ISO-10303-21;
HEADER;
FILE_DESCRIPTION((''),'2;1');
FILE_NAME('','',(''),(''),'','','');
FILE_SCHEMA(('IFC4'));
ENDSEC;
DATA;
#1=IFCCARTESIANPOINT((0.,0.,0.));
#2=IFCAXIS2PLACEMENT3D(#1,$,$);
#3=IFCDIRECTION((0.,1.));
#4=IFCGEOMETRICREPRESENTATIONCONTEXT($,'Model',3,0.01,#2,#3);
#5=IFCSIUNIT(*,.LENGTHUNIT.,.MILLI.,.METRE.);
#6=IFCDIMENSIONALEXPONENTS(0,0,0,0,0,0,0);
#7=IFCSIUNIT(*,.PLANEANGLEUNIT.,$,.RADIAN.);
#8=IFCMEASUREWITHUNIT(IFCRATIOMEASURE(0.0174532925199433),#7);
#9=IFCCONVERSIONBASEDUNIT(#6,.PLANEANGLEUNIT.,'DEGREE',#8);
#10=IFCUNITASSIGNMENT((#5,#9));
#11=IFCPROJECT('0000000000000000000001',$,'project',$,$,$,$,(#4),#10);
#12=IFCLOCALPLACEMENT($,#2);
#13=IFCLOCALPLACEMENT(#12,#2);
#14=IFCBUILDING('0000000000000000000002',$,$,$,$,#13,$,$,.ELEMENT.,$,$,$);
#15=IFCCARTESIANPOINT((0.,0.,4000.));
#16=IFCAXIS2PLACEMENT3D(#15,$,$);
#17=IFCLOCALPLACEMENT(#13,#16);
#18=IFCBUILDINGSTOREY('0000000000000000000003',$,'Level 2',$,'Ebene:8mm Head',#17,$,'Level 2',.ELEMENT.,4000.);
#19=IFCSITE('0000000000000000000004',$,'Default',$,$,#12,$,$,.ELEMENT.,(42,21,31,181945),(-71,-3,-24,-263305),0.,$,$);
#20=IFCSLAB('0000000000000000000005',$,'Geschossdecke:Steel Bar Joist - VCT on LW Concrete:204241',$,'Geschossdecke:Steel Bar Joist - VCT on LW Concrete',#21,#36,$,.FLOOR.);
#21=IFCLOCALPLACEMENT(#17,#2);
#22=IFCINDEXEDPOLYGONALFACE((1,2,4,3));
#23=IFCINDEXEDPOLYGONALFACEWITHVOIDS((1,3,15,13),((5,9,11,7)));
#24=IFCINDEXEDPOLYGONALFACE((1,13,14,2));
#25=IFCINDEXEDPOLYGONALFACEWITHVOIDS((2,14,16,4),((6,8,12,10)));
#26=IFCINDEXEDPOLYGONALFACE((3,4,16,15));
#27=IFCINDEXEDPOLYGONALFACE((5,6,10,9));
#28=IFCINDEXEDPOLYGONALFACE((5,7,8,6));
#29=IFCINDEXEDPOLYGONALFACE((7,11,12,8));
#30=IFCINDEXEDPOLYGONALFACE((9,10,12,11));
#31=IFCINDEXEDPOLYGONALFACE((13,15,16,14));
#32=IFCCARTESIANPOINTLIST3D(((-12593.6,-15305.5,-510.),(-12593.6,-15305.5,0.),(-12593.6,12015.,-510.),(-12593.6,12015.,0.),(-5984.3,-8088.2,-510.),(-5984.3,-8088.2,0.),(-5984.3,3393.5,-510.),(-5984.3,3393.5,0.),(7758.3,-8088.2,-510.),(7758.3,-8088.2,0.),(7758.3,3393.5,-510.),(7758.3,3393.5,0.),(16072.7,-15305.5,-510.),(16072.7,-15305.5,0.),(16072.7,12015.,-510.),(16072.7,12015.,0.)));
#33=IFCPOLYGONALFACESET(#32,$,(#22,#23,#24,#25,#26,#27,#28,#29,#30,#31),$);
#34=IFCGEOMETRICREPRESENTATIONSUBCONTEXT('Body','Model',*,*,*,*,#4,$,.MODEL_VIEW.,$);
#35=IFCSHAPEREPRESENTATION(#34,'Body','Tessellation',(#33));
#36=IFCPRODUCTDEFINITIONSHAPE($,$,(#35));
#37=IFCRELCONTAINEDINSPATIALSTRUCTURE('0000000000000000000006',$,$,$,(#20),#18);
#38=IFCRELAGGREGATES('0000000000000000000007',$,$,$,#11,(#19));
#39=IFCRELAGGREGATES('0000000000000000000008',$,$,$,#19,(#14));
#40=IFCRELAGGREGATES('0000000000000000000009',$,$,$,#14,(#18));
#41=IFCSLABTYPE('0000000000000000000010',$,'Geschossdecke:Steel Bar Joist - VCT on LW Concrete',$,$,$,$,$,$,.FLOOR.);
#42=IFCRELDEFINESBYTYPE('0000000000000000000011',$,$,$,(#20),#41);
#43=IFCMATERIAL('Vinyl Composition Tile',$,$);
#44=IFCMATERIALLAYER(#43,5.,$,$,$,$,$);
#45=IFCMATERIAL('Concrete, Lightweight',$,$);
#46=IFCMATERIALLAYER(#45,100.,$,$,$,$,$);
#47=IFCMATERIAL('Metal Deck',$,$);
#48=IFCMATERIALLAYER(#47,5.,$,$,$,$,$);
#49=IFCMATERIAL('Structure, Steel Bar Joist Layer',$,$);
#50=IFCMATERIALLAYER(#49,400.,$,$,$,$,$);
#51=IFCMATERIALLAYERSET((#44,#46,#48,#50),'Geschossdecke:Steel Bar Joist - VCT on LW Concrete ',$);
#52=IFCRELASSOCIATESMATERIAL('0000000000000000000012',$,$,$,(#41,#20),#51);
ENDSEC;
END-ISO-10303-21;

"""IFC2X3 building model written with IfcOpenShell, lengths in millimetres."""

from ifc_helpers import new_model, entity, si_unit, converted_unit, direction, frame, frame_2d, origin, origin_2d_with_axis, place, context, subcontext, project, spatial, rectangle, extrude, material, layer, layer_set, layer_usage, type_object, element, save


model = new_model("IFC2X3")

# Units and contexts
model_context = context("Model", 3, precision=0.01, world=origin(), true_north=direction((0.0, 1.0)))
body_context = subcontext(model_context, "Body", "Model", "MODEL_VIEW")
ifc_project = project(units=[si_unit("LENGTHUNIT", "METRE", prefix="MILLI"), converted_unit("PLANEANGLEUNIT", "DEGREE", entity("IfcRatioMeasure", 0.0174532925199433), si_unit("PLANEANGLEUNIT", "RADIAN"), dimensions=[0, 0, 0, 0, 0, 0, 0])], contexts=[model_context])

# Site, building, storey
site_placement = place(None, origin())
site = spatial("IfcSite", under=ifc_project, at=site_placement, Name="Default", CompositionType="ELEMENT", RefLatitude=(42, 21, 31, 181945), RefLongitude=(-71, -3, -24, -263305), RefElevation=0.0)
building_placement = place(site_placement, origin())
building = spatial("IfcBuilding", under=site, at=building_placement, CompositionType="ELEMENT")
storey_placement = place(building_placement, frame((0.0, 0.0, 4000.0)))
storey = spatial("IfcBuildingStorey", under=building, at=storey_placement, Name="Level 2", ObjectType="Ebene:8mm Head", LongName="Level 2", CompositionType="ELEMENT", Elevation=4000.0)

# Slab, opening
ifc_material_1 = material(Name="Vinyl Composition Tile")
ifc_layer_1 = layer(ifc_material_1, 5.0)
ifc_material_2 = material(Name="Concrete, Lightweight")
ifc_layer_2 = layer(ifc_material_2, 100.0)
ifc_material_3 = material(Name="Metal Deck")
ifc_layer_3 = layer(ifc_material_3, 5.0)
ifc_material_4 = material(Name="Structure, Steel Bar Joist Layer")
ifc_layer_4 = layer(ifc_material_4, 400.0)
ifc_layer_set = layer_set([ifc_layer_1, ifc_layer_2, ifc_layer_3, ifc_layer_4], Name="Geschossdecke:Steel Bar Joist - VCT on LW Concrete ")
ifc_layer_usage = layer_usage(ifc_layer_set, "AXIS3", "POSITIVE", 0.0)
slab_type = type_object("IfcSlabType", Name="Geschossdecke:Steel Bar Joist - VCT on LW Concrete", PredefinedType="FLOOR", material=ifc_layer_set)
slab_placement = place(storey_placement, frame((-12593.6, -15305.5, -510.0)))
slab = element("IfcSlab", 1, at=slab_placement, inside=storey, type_object=slab_type, material=ifc_layer_usage, Name="Geschossdecke:Steel Bar Joist - VCT on LW Concrete:204241", ObjectType="Geschossdecke:Steel Bar Joist - VCT on LW Concrete", PredefinedType="FLOOR", context=body_context, shape_type="SweptSolid", body=[
    extrude(rectangle(XDim=27320.5, YDim=28666.3, at=frame_2d((0.0, 0.0), x_axis=(0.0, -1.0))), frame((14333.1, 13660.3, 510.0), z_axis=(0.0, 0.0, -1.0), x_axis=(-1.0, 0.0, 0.0)), (0.0, 0.0, 1.0), 510.0),
])
opening_placement = place(slab_placement, frame((13480.6, 12958.1, 510.0)))
element("IfcOpeningElement", 2, at=opening_placement, cuts=slab, ObjectType="Opening", context=body_context, shape_type="SweptSolid", body=[
    extrude(rectangle(XDim=13742.6, YDim=11481.7, at=origin_2d_with_axis()), frame((0.0, 0.0, 0.0), z_axis=(0.0, 0.0, -1.0), x_axis=(-1.0, 0.0, 0.0)), (0.0, 0.0, 1.0), 510.0),
])

save(model, "model.ifc")
